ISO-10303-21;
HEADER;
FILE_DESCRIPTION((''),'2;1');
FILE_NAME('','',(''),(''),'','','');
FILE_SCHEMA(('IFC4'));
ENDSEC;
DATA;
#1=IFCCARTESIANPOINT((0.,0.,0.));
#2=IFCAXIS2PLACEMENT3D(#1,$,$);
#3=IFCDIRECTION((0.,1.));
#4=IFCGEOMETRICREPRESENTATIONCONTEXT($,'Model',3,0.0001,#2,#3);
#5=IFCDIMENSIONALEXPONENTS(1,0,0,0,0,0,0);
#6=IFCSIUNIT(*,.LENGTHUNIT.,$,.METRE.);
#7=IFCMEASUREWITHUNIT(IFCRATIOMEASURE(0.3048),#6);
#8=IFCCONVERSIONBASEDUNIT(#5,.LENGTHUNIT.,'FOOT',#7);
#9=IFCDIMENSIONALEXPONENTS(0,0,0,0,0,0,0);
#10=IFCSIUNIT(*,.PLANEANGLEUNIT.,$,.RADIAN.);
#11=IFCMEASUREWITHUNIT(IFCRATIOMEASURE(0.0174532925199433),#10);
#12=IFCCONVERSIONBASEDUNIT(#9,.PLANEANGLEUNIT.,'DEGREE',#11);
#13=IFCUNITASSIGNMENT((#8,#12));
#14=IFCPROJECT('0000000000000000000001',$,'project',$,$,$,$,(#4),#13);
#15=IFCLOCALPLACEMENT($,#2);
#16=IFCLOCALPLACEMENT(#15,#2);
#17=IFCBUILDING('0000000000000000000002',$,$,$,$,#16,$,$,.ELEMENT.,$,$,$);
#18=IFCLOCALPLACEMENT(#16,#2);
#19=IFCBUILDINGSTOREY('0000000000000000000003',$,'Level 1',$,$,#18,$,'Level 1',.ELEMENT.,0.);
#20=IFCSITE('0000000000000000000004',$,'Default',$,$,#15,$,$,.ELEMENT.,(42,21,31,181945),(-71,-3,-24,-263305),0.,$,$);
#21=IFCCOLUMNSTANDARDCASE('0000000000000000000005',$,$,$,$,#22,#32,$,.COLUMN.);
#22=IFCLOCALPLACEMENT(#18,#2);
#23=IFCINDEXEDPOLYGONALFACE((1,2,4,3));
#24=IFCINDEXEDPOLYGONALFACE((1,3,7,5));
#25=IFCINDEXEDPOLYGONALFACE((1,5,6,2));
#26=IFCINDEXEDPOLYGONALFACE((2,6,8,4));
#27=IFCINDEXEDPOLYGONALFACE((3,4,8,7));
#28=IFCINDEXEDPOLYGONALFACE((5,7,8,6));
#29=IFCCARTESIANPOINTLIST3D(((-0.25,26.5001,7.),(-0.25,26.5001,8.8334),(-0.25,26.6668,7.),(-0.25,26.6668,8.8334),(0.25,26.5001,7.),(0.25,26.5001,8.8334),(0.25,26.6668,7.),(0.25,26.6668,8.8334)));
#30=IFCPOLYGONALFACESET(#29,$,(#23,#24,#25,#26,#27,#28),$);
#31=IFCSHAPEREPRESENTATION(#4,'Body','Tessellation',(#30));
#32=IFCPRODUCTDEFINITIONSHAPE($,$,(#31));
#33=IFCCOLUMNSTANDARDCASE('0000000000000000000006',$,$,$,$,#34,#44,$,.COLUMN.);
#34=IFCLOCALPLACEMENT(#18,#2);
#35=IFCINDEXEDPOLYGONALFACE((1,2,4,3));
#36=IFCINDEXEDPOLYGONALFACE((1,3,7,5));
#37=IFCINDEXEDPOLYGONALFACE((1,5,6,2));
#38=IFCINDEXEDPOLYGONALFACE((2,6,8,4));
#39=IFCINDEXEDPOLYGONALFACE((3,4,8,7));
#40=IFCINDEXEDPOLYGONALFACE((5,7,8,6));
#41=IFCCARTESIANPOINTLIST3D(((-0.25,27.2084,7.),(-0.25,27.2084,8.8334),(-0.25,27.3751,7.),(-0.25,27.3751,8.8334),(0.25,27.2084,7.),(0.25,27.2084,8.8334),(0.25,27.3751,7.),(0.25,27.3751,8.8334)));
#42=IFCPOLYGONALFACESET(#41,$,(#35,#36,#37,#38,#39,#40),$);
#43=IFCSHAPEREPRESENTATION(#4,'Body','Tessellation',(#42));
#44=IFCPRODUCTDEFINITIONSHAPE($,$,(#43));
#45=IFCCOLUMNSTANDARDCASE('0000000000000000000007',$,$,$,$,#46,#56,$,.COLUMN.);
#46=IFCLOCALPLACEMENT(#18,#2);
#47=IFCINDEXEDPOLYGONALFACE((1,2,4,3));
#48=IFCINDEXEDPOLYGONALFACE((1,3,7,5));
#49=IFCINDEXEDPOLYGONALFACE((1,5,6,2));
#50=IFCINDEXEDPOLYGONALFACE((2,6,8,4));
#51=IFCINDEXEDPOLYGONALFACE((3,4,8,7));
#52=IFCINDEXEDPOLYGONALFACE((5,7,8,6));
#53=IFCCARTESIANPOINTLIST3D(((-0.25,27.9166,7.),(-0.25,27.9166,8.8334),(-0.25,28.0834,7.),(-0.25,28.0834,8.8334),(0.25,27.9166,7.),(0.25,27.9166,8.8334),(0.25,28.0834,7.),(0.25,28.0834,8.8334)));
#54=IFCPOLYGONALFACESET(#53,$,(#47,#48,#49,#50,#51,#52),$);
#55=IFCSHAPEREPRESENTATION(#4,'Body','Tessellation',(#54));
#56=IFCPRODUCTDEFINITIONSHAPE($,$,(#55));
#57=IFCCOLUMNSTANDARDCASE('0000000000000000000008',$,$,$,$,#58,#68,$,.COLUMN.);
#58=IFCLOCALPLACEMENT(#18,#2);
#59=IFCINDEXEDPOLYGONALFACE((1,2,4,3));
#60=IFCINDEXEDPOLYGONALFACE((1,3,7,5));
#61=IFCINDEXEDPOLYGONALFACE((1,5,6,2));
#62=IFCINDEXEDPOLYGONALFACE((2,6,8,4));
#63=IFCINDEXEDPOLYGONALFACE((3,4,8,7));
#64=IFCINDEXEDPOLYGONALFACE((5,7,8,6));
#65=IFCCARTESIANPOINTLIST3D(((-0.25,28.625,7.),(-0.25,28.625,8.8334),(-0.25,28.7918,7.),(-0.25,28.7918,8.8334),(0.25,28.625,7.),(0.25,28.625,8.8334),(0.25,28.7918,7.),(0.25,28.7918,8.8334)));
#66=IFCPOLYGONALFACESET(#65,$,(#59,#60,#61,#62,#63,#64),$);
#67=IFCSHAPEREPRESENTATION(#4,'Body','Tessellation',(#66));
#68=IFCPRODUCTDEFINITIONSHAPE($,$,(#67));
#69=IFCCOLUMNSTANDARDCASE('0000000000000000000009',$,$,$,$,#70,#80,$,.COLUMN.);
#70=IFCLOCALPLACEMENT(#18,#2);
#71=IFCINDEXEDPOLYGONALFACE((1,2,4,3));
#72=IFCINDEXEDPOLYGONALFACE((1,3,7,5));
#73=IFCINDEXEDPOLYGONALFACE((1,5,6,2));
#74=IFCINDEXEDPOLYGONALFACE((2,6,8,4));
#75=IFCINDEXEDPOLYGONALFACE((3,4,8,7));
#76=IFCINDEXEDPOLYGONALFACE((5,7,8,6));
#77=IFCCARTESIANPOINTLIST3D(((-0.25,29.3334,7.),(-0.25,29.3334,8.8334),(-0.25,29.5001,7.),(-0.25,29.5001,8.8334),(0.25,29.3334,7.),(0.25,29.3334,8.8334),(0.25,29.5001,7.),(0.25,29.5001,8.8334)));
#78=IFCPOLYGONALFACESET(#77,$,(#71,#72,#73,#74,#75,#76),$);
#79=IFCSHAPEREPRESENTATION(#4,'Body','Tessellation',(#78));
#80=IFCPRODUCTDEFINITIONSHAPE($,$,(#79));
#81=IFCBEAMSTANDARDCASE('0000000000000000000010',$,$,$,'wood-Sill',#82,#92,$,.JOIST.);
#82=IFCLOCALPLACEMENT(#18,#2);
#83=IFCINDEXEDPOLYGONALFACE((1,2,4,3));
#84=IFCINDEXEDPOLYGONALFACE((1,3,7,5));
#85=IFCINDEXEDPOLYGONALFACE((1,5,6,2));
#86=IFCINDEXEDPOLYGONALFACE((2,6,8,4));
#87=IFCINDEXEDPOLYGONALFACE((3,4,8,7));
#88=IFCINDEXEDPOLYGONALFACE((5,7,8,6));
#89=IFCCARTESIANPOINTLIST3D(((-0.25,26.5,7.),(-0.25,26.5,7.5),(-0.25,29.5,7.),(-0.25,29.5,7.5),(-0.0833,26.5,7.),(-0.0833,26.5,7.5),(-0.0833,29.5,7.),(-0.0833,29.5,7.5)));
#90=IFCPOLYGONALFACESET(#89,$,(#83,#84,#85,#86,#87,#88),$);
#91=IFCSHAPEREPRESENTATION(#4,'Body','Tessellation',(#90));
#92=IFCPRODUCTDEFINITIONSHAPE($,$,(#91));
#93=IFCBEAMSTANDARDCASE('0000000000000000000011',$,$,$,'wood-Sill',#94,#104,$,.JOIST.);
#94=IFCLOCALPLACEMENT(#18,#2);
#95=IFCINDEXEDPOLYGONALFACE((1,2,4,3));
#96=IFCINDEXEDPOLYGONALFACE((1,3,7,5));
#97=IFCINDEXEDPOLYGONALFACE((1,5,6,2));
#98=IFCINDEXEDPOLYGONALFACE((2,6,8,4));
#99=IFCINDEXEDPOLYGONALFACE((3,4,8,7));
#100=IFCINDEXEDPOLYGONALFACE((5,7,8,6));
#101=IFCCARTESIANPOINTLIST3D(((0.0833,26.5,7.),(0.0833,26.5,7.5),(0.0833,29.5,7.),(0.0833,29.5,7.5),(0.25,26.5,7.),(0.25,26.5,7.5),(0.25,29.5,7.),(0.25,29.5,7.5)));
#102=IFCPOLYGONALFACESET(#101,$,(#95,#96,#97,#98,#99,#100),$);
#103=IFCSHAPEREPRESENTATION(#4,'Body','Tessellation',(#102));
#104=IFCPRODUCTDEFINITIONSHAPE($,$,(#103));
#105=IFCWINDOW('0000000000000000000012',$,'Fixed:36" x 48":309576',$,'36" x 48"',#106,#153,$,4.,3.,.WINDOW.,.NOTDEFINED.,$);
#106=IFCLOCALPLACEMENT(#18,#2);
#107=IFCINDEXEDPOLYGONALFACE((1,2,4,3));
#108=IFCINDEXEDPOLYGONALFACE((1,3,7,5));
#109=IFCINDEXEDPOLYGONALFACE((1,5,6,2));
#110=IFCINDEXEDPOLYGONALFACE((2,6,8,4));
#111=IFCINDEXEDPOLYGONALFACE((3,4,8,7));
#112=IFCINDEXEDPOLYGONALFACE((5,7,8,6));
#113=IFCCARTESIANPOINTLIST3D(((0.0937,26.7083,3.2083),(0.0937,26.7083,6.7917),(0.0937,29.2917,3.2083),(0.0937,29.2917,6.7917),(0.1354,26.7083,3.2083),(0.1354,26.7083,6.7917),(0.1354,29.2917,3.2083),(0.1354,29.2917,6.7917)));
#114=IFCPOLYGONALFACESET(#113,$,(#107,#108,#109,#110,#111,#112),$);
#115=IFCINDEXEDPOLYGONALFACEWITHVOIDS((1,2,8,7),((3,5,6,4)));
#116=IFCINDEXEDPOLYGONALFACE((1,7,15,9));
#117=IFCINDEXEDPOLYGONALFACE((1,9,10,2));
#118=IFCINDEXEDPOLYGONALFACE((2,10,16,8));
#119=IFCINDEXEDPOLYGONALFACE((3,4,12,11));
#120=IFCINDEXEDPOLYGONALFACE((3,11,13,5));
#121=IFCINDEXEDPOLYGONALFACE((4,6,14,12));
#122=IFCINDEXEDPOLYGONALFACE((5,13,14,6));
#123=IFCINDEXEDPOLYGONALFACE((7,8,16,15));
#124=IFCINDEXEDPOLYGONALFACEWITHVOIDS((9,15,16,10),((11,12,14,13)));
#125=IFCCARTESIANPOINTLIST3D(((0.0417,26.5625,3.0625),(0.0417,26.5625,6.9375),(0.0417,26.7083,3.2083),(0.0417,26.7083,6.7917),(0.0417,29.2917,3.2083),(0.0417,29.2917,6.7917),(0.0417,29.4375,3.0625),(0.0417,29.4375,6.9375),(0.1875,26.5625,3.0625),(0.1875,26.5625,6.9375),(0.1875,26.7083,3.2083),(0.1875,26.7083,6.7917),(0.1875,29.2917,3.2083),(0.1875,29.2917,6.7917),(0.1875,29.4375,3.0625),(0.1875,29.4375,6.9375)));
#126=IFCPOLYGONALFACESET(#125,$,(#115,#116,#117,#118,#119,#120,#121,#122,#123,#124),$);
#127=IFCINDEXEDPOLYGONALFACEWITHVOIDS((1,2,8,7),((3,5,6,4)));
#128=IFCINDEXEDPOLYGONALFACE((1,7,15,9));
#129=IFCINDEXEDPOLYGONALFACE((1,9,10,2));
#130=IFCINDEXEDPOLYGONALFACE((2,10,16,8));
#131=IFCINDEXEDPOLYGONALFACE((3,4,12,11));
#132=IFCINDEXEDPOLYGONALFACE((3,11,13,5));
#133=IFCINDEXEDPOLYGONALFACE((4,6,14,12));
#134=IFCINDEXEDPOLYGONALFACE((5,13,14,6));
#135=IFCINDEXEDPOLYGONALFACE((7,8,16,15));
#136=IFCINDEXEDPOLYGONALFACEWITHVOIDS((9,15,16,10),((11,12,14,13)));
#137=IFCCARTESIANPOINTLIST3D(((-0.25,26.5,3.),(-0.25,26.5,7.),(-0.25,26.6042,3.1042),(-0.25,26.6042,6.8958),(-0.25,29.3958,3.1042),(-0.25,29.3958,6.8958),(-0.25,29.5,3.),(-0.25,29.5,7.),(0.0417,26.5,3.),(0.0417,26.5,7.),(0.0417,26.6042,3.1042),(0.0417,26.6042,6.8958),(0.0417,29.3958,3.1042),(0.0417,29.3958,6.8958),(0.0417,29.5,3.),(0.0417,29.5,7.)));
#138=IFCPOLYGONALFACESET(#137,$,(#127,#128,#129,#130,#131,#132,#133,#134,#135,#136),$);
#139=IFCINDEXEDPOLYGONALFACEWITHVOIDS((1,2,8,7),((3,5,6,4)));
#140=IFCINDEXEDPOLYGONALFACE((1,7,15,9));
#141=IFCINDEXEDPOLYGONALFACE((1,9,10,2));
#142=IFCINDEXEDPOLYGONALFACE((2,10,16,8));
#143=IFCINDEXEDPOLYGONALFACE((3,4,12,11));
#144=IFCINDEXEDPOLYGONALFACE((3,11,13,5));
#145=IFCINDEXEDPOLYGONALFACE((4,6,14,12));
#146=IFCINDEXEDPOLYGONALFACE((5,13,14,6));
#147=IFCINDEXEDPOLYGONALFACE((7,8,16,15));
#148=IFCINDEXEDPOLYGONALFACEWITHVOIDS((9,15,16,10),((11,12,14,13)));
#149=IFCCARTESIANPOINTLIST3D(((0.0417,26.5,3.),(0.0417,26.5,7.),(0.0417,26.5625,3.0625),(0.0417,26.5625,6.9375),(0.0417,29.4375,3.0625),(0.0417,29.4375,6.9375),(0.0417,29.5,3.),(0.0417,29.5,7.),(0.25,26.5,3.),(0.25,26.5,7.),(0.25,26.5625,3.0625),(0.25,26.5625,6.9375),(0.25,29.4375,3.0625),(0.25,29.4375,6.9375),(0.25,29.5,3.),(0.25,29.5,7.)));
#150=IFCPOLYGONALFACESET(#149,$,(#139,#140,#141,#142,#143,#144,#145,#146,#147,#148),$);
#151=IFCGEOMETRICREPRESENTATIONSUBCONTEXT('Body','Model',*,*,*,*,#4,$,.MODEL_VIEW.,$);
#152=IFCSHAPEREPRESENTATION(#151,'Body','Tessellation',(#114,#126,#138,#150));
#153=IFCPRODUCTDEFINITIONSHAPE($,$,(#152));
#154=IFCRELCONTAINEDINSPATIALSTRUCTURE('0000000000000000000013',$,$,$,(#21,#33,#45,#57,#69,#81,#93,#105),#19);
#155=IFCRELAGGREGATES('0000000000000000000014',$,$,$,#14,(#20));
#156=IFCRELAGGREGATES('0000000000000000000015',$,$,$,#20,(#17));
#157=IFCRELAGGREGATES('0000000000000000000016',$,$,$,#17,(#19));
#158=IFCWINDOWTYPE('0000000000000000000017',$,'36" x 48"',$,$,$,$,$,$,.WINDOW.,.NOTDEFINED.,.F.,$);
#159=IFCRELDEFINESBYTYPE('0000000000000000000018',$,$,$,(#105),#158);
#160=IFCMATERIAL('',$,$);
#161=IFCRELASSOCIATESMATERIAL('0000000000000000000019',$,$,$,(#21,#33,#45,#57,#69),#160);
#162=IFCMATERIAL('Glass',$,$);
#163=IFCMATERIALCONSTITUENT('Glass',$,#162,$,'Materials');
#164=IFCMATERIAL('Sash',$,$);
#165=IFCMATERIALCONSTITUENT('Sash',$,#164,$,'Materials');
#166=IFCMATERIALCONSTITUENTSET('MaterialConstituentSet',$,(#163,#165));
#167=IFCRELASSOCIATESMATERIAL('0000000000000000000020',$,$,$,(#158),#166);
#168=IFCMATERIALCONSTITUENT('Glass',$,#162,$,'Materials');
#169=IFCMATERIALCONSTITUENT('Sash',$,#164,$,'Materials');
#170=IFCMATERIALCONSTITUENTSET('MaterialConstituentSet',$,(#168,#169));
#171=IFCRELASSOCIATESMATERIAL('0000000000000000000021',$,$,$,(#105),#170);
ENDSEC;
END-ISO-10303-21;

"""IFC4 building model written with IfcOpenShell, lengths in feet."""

from ifc_helpers import new_model, entity, si_unit, converted_unit, direction, frame, frame_2d, origin, origin_with_axes, place, context, subcontext, project, spatial, polyline, rectangle, outline, extrude, source, transform, mapped, material, constituent, constituent_set, type_object, type_shapes, element, save


model = new_model("IFC4")

# Units and contexts
model_context = context("Model", 3, precision=0.0001, world=origin(), true_north=direction((0.0, 1.0)))
body_context = subcontext(model_context, "Body", "Model", "MODEL_VIEW")
ifc_project = project(units=[converted_unit("LENGTHUNIT", "FOOT", entity("IfcRatioMeasure", 0.3048), si_unit("LENGTHUNIT", "METRE"), dimensions=[1, 0, 0, 0, 0, 0, 0]), converted_unit("PLANEANGLEUNIT", "DEGREE", entity("IfcRatioMeasure", 0.0174532925199433), si_unit("PLANEANGLEUNIT", "RADIAN"), dimensions=[0, 0, 0, 0, 0, 0, 0])], contexts=[model_context])

# Site, building, storey
site_placement = place(None, origin())
site = spatial("IfcSite", under=ifc_project, at=site_placement, Name="Default", CompositionType="ELEMENT", RefLatitude=(42, 21, 31, 181945), RefLongitude=(-71, -3, -24, -263305), RefElevation=0.0)
building_placement = place(site_placement, origin())
building = spatial("IfcBuilding", under=site, at=building_placement, CompositionType="ELEMENT")
storey_placement = place(building_placement, origin())
storey = spatial("IfcBuildingStorey", under=building, at=storey_placement, Name="Level 1", LongName="Level 1", CompositionType="ELEMENT", Elevation=0.0)

# Columns
placement_1 = place(storey_placement, frame((0.0, -0.25, 0.0), z_axis=(0.0, 0.0, 1.0), x_axis=(0.0, 1.0, 0.0)))
ifc_material_1 = material(Name="")
for number, where, z_axis, x_axis in (
    (1, (26.8334, 0.0, 7.0), (0.0, 0.0, 1.0), (1.0, 0.0, 0.0)),
    (2, (27.5417, 0.0, 7.0), (0.0, 0.0, 1.0), (1.0, 0.0, 0.0)),
    (3, (28.25, 0.0, 7.0), (0.0, 0.0, 1.0), (1.0, 0.0, 0.0)),
    (4, (28.9584, 0.0, 7.0), (0.0, 0.0, 1.0), (1.0, 0.0, 0.0)),
    (5, (29.6667, 0.0, 7.0), (0.0, 0.0, 1.0), (1.0, 0.0, 0.0)),
):
    element("IfcColumnStandardCase", number, at=place(placement_1, frame(where, z_axis=z_axis, x_axis=x_axis)), inside=storey, material=ifc_material_1, PredefinedType="COLUMN", context=model_context, shape_type="SweptSolid", body=[
        extrude(rectangle(XDim=0.1667, YDim=0.5), origin(), (0.0, 0.0, 1.0), 1.8334),
    ])

# Beams
for number, where, z_axis, x_axis in (
    (6, (26.75, 0.1667, 7.25), (1.0, 0.0, 0.0), (0.0, 0.0, 1.0)),
    (7, (26.75, -0.1667, 7.25), (1.0, 0.0, 0.0), (0.0, 0.0, 1.0)),
):
    element("IfcBeamStandardCase", number, at=place(placement_1, frame(where, z_axis=z_axis, x_axis=x_axis)), inside=storey, ObjectType="wood-Sill", PredefinedType="JOIST", context=model_context, shape_type="SweptSolid", body=[
        extrude(rectangle(XDim=0.5, YDim=0.1667), origin_with_axes(), (0.0, 0.0, 1.0), 3.0),
    ])

# Window
ifc_material_2 = material(Name="Glass")
ifc_constituent_1 = constituent(ifc_material_2, Name="Glass", Category="Materials")
ifc_material_3 = material(Name="Sash")
ifc_constituent_2 = constituent(ifc_material_3, Name="Sash", Category="Materials")
ifc_constituent_set_1 = constituent_set(constituents=[ifc_constituent_1, ifc_constituent_2], Name="MaterialConstituentSet")
ifc_constituent_3 = constituent(ifc_material_2, Name="Glass", Category="Materials")
ifc_constituent_4 = constituent(ifc_material_3, Name="Sash", Category="Materials")
ifc_constituent_set_2 = constituent_set(constituents=[ifc_constituent_3, ifc_constituent_4], Name="MaterialConstituentSet")
window_type = type_object("IfcWindowType", Name="36\" x 48\"", ParameterTakesPrecedence=False, PartitioningType="NOTDEFINED", PredefinedType="WINDOW", material=ifc_constituent_set_2)
shared_shape = source(origin(), body_context, "Body", "SweptSolid", [
    extrude(rectangle(XDim=0.0417, YDim=2.5833, at=frame_2d((0.0, 0.0), x_axis=(1.0, 0.0))), frame((1.5, 0.3646, 0.2083), z_axis=(0.0, 0.0, 1.0), x_axis=(0.0, 1.0, 0.0)), (0.0, 0.0, 1.0), 3.5833),
    extrude(outline(polyline([(-1.4375, -1.9375), (1.4375, -1.9375), (1.4375, 1.9375), (-1.4375, 1.9375), (-1.4375, -1.9375)]), holes=[polyline([(-1.2917, -1.7917), (-1.2917, 1.7917), (1.2917, 1.7917), (1.2917, -1.7917), (-1.2917, -1.7917)])]), frame((1.5, 0.2917, 2.0), z_axis=(0.0, 1.0, 0.0), x_axis=(1.0, 0.0, 0.0)), (0.0, 0.0, 1.0), 0.1458),
    extrude(outline(polyline([(-1.5, -2.0), (1.5, -2.0), (1.5, 2.0), (-1.5, 2.0), (-1.5, -2.0)]), holes=[polyline([(-1.3958, -1.8958), (-1.3958, 1.8958), (1.3958, 1.8958), (1.3958, -1.8958), (-1.3958, -1.8958)])]), frame((1.5, 0.0, 2.0), z_axis=(0.0, 1.0, 0.0), x_axis=(1.0, 0.0, 0.0)), (0.0, 0.0, 1.0), 0.2917),
    extrude(outline(polyline([(-2.0, -1.5), (2.0, -1.5), (2.0, 1.5), (-2.0, 1.5), (-2.0, -1.5)]), holes=[polyline([(-1.9375, -1.4375), (-1.9375, 1.4375), (1.9375, 1.4375), (1.9375, -1.4375), (-1.9375, -1.4375)])]), frame((1.5, 0.2917, 2.0), z_axis=(0.0, 1.0, 0.0), x_axis=(0.0, 0.0, -1.0)), (0.0, 0.0, 1.0), 0.2083),
])
type_shapes(window_type, [shared_shape])
placement_2 = place(placement_1, frame((29.75, 0.25, 3.0)))
window_placement = place(placement_2, frame((0.0, 0.0, 0.0), z_axis=(0.0, 0.0, 1.0), x_axis=(-1.0, 0.0, 0.0)))
element("IfcWindow", 8, at=window_placement, inside=storey, type_object=window_type, material=ifc_constituent_set_1, Name="Fixed:36\" x 48\":309576", ObjectType="36\" x 48\"", OverallHeight=4.0, OverallWidth=3.0, PartitioningType="NOTDEFINED", PredefinedType="WINDOW", context=body_context, shape_type="MappedRepresentation", body=[
    mapped(shared_shape, transform((0.0, 0.0, 0.0), scale=1.0)),
])

save(model, "model.ifc")
